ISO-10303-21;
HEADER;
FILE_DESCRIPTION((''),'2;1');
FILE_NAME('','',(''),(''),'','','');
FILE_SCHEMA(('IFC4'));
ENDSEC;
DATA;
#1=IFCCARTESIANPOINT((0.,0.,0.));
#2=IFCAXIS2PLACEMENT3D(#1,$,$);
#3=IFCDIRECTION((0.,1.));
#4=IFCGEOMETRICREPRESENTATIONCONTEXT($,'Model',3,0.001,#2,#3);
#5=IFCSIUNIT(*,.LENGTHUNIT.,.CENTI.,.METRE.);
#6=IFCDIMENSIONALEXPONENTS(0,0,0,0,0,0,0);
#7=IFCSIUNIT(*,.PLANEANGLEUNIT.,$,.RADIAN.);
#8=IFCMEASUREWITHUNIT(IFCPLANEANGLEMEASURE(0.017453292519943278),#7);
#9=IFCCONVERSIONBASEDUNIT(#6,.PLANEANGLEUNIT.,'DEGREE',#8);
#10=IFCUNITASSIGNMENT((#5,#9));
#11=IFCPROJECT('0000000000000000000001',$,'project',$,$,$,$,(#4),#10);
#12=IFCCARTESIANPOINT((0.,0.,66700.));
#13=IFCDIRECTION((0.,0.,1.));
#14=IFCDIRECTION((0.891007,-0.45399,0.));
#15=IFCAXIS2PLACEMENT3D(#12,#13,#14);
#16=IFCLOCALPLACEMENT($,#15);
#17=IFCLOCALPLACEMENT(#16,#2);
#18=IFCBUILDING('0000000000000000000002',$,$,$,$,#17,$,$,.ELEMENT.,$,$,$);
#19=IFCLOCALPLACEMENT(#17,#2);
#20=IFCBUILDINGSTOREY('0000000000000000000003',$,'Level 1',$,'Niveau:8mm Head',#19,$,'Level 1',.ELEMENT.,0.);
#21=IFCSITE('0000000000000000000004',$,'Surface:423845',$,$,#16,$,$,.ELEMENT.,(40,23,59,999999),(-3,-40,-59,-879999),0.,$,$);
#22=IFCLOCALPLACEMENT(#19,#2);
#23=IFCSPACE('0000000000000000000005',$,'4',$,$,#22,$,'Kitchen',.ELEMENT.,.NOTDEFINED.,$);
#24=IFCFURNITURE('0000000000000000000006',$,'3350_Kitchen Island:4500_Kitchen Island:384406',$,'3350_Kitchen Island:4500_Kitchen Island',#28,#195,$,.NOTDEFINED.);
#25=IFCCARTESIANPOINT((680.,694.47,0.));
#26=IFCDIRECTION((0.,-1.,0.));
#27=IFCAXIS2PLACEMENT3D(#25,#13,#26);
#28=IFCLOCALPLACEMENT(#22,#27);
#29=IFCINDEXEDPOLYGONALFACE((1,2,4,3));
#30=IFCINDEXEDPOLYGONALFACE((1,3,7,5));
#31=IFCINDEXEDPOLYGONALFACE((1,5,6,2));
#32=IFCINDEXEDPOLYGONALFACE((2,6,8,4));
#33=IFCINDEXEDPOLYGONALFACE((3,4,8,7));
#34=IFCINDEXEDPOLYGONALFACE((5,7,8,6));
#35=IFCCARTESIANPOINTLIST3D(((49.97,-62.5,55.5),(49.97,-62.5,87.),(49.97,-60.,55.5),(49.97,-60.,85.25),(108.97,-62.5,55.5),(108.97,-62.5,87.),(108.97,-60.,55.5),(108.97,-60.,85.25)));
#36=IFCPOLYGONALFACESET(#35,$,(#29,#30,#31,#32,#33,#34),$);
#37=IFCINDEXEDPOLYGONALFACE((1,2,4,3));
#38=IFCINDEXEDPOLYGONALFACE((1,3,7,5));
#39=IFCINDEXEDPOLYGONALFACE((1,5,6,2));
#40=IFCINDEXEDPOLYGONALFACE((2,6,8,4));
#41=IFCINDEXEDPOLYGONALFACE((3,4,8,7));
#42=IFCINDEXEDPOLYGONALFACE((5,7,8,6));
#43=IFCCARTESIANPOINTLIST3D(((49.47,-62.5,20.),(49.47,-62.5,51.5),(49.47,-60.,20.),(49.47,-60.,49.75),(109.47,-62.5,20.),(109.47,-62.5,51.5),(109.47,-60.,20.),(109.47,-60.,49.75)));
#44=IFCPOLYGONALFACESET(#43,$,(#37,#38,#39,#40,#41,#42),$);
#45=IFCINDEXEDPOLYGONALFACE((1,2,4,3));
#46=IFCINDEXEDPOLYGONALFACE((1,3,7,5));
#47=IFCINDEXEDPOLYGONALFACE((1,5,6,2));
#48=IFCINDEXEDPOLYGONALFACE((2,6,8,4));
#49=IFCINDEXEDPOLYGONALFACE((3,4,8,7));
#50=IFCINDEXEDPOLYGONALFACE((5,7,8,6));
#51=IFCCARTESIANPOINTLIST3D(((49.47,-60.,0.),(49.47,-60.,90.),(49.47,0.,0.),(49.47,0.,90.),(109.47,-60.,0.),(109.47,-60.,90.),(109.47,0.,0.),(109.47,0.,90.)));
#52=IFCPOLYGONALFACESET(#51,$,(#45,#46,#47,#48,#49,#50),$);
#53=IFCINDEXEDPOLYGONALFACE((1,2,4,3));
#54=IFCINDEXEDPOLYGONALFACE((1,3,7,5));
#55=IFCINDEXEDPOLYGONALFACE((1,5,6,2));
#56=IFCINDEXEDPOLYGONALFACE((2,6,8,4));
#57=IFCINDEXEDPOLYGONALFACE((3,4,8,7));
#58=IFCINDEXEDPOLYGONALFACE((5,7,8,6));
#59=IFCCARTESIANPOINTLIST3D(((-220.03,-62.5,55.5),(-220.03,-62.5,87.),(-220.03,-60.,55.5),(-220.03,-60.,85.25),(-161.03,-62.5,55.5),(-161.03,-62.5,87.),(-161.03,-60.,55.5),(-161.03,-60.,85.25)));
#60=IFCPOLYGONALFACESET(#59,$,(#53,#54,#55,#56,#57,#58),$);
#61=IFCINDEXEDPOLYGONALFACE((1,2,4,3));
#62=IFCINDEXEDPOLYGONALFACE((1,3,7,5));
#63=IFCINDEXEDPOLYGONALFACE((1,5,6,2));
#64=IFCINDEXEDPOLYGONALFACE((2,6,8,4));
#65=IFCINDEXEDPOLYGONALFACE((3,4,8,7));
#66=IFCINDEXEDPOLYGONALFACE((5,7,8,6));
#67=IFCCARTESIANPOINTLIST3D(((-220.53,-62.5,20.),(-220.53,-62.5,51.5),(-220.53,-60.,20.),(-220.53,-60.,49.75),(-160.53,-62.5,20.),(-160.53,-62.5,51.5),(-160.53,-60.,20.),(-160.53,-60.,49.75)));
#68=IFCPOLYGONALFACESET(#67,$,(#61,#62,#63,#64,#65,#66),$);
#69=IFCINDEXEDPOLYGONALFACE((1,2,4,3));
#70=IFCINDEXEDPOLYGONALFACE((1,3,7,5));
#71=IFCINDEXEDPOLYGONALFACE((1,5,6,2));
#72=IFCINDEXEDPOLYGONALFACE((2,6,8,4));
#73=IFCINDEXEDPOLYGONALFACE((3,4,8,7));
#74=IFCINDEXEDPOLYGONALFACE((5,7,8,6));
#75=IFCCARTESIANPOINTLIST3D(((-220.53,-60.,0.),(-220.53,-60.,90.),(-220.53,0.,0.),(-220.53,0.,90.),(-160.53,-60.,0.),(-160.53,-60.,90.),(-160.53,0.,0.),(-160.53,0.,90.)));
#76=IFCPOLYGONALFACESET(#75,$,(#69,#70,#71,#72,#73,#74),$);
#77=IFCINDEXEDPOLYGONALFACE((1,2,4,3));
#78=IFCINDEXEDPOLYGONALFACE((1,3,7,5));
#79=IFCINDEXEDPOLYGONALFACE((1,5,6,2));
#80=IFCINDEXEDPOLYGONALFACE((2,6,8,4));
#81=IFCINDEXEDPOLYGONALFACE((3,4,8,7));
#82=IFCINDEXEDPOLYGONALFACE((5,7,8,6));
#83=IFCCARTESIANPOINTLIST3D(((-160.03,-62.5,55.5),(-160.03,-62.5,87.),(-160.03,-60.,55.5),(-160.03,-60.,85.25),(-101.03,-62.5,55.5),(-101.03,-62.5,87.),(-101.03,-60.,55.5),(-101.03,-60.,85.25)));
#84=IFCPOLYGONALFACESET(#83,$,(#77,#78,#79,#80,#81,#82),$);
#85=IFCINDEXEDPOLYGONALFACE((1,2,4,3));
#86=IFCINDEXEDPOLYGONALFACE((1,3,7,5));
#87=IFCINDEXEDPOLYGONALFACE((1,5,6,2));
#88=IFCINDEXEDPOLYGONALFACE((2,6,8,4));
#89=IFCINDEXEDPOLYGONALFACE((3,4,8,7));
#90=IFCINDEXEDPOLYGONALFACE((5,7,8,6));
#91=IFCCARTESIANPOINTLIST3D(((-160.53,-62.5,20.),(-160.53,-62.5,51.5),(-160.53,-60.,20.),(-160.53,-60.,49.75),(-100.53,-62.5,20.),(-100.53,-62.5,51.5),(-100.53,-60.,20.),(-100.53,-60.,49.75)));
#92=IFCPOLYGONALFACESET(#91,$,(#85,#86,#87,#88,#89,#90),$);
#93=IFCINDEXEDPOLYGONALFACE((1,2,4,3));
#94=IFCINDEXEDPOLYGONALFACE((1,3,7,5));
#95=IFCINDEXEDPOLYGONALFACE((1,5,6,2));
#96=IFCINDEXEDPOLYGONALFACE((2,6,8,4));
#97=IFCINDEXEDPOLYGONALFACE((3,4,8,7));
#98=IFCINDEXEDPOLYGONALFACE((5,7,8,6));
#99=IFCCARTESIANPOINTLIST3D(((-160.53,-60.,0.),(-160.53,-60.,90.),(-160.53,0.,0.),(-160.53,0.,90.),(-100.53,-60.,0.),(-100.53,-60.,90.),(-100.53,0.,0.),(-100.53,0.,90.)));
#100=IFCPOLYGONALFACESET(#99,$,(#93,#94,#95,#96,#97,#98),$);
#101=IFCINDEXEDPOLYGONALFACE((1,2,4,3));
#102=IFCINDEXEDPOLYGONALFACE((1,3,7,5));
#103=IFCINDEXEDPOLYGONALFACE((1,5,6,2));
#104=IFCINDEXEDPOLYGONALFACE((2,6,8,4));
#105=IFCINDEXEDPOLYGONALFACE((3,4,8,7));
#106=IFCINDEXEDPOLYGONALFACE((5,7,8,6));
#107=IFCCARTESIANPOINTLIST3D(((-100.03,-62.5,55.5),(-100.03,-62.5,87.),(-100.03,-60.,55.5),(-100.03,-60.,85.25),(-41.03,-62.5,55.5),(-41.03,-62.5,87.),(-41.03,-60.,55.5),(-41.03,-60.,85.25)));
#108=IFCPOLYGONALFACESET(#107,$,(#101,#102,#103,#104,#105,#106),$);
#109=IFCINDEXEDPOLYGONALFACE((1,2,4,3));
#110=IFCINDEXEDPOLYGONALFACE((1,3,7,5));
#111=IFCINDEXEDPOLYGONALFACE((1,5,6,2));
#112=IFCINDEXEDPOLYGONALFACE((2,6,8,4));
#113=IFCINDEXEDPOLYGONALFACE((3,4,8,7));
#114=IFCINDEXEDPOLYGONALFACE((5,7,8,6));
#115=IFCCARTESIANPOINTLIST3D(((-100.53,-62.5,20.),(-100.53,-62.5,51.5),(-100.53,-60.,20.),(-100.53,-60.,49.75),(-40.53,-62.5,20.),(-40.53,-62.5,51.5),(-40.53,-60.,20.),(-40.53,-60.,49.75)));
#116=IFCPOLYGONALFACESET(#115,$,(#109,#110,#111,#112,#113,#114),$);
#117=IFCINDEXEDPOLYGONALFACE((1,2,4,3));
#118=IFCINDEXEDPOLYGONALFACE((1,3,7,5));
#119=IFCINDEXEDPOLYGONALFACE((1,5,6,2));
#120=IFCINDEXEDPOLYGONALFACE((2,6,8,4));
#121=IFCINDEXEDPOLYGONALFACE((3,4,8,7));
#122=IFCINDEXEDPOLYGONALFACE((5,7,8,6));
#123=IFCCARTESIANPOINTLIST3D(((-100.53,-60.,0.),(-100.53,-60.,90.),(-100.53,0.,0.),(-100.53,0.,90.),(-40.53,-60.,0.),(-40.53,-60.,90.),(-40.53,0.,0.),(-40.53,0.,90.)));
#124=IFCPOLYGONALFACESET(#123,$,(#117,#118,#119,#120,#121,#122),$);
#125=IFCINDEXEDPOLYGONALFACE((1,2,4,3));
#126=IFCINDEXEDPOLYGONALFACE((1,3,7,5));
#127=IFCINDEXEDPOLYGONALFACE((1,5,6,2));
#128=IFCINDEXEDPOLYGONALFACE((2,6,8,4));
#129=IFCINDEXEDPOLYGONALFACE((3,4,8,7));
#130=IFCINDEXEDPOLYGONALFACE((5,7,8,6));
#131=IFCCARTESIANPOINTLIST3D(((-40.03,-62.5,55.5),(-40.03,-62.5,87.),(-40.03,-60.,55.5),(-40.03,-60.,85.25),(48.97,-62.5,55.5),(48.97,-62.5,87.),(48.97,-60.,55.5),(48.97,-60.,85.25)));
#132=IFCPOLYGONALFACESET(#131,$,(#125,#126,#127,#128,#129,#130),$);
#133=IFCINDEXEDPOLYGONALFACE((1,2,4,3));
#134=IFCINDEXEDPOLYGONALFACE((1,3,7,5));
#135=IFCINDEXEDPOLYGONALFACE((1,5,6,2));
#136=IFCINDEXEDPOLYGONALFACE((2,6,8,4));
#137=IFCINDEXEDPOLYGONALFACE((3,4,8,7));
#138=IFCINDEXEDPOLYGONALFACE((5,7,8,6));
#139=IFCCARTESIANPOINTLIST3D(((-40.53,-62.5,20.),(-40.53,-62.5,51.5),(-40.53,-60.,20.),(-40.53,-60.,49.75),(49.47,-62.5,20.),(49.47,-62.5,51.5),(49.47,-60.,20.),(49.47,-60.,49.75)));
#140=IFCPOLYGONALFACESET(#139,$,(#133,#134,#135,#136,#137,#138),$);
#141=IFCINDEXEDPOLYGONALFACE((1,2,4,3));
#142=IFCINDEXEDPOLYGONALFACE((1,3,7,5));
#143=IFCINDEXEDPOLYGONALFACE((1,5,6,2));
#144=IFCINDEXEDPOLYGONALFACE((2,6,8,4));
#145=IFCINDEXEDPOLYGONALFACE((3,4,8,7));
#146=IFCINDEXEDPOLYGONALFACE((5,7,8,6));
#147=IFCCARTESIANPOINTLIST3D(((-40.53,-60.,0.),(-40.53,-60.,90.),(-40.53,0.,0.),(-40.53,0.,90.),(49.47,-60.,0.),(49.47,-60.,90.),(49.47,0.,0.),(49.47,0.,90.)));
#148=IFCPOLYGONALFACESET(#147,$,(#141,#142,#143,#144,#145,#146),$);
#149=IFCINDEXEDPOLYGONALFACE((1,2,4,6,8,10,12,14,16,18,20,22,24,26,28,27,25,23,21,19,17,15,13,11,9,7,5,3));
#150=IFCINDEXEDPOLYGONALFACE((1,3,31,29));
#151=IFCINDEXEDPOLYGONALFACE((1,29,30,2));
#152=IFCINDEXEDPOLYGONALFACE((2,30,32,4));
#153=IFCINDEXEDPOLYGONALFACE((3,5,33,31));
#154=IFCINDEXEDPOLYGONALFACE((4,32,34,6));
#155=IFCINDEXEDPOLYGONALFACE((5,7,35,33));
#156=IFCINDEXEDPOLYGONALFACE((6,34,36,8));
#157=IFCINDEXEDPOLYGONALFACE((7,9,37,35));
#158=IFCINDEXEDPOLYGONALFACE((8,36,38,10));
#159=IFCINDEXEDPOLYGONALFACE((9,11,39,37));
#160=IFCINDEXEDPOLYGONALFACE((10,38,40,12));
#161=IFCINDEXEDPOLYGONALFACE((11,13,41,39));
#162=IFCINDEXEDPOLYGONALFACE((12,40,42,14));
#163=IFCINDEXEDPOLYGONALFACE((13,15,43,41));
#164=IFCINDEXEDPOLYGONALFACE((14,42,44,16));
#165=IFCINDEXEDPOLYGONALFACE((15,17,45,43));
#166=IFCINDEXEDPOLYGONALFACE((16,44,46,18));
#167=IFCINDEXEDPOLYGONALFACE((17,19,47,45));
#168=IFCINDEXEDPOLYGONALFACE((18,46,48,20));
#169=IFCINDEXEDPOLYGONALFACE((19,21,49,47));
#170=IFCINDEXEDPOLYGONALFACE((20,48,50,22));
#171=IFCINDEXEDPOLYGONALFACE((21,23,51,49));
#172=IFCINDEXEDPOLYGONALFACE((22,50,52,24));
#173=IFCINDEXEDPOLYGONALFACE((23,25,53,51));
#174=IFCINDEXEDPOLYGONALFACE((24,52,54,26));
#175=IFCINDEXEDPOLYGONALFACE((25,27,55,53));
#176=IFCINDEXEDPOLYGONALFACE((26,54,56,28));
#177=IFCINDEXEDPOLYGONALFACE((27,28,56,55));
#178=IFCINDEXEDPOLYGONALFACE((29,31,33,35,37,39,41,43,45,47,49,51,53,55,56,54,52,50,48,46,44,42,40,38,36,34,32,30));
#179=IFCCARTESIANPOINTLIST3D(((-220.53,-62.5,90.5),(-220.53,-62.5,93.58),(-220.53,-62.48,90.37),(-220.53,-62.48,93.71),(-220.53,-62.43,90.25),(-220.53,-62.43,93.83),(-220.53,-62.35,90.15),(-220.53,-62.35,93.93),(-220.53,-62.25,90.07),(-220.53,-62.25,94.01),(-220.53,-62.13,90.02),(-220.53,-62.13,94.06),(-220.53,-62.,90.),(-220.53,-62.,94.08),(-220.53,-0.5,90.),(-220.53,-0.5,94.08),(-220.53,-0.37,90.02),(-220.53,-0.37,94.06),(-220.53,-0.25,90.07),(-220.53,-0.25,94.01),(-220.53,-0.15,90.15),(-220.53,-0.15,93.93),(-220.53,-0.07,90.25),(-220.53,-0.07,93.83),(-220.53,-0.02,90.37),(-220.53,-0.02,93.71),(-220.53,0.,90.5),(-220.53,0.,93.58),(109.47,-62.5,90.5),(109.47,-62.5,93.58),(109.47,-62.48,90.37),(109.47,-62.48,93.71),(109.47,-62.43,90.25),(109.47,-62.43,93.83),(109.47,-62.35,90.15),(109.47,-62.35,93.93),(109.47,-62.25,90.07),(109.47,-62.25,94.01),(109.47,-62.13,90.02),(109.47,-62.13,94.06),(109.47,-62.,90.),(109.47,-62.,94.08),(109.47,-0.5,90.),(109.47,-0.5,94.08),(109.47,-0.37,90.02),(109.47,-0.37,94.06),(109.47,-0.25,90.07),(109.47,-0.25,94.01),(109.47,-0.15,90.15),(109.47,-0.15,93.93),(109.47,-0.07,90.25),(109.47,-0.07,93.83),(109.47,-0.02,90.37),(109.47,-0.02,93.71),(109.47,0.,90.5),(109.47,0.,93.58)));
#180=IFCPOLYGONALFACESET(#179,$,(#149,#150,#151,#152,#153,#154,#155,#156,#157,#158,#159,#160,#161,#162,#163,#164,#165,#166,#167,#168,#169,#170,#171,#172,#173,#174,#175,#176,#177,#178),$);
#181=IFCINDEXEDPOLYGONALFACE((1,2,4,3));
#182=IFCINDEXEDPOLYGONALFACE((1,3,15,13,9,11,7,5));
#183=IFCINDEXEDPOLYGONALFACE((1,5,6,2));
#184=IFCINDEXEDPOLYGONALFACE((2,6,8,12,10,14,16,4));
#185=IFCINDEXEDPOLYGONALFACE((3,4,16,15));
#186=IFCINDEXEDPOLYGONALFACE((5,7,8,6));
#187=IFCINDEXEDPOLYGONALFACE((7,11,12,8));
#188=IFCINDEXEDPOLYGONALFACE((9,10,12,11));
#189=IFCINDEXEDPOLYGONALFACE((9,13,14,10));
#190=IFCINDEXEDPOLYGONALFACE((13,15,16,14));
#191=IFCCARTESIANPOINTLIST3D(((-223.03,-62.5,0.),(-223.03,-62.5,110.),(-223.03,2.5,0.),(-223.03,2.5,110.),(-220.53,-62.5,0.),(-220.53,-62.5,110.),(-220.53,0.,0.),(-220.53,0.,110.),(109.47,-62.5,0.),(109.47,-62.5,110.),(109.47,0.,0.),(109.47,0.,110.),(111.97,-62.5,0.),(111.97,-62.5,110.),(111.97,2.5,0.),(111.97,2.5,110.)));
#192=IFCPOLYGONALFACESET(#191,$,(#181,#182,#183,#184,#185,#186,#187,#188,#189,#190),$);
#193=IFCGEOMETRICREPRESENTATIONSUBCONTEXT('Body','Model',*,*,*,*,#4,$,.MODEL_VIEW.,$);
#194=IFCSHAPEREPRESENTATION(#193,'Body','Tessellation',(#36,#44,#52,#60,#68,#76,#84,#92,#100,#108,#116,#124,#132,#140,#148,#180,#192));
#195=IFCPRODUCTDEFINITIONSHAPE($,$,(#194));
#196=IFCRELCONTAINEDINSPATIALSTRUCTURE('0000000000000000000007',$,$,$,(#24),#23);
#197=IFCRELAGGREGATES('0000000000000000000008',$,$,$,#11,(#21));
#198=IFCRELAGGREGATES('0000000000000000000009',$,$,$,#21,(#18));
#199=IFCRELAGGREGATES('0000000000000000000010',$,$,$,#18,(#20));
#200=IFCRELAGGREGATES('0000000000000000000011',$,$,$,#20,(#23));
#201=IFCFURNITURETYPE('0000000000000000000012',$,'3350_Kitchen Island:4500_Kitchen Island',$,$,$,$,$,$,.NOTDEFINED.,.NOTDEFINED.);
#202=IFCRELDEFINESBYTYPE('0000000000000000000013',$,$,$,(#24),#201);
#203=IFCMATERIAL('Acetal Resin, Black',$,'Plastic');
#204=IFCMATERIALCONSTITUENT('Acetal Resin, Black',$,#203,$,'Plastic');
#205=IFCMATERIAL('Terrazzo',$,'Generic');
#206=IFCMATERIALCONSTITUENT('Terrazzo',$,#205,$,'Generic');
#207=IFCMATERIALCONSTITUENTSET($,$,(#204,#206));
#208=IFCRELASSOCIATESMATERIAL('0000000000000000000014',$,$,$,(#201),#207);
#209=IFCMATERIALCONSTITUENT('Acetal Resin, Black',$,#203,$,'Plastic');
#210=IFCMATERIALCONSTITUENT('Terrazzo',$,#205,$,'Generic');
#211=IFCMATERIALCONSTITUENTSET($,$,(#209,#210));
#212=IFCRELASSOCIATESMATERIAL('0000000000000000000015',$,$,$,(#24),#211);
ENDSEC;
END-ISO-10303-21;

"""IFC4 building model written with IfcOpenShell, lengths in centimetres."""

from ifc_helpers import new_model, entity, si_unit, converted_unit, direction, frame, frame_2d, origin, place, context, subcontext, project, spatial, polyline, circle_curve, parameter, trimmed, segment, composite_curve, rectangle, outline, extrude, source, transform, mapped, material, constituent, constituent_set, type_object, type_shapes, element, save


model = new_model("IFC4")

# Units and contexts
model_context = context("Model", 3, precision=0.001, world=origin(), true_north=direction((0.0, 1.0)))
body_context = subcontext(model_context, "Body", "Model", "MODEL_VIEW")
ifc_project = project(units=[si_unit("LENGTHUNIT", "METRE", prefix="CENTI"), converted_unit("PLANEANGLEUNIT", "DEGREE", entity("IfcPlaneAngleMeasure", 0.017453292519943278), si_unit("PLANEANGLEUNIT", "RADIAN"), dimensions=[0, 0, 0, 0, 0, 0, 0])], contexts=[model_context])

# Site, building, storey
site_placement = place(None, frame((0.0, 0.0, 66700.0), z_axis=(0.0, 0.0, 1.0), x_axis=(0.891007, -0.45399, 0.0)))
site = spatial("IfcSite", under=ifc_project, at=site_placement, Name="Surface:423845", CompositionType="ELEMENT", RefLatitude=(40, 23, 59, 999999), RefLongitude=(-3, -40, -59, -879999), RefElevation=0.0)
building_placement = place(site_placement, origin())
building = spatial("IfcBuilding", under=site, at=building_placement, CompositionType="ELEMENT")
storey_placement = place(building_placement, origin())
storey = spatial("IfcBuildingStorey", under=building, at=storey_placement, Name="Level 1", ObjectType="Niveau:8mm Head", LongName="Level 1", CompositionType="ELEMENT", Elevation=0.0)

# Shared definitions
space_placement = place(storey_placement, origin())
space = spatial("IfcSpace", under=storey, at=space_placement, Name="4", LongName="Kitchen", CompositionType="ELEMENT", PredefinedType="NOTDEFINED")

# Furniture
ifc_material_1 = material(Name="Acetal Resin, Black", Category="Plastic")
ifc_constituent_1 = constituent(ifc_material_1, Name="Acetal Resin, Black", Category="Plastic")
ifc_material_2 = material(Name="Terrazzo", Category="Generic")
ifc_constituent_2 = constituent(ifc_material_2, Name="Terrazzo", Category="Generic")
ifc_constituent_set_1 = constituent_set(constituents=[ifc_constituent_1, ifc_constituent_2])
ifc_constituent_3 = constituent(ifc_material_1, Name="Acetal Resin, Black", Category="Plastic")
ifc_constituent_4 = constituent(ifc_material_2, Name="Terrazzo", Category="Generic")
ifc_constituent_set_2 = constituent_set(constituents=[ifc_constituent_3, ifc_constituent_4])
furniture_type_1 = type_object("IfcFurnitureType", Name="3350_Kitchen Island:4500_Kitchen Island", AssemblyPlace="NOTDEFINED", PredefinedType="NOTDEFINED", material=ifc_constituent_set_2)
shared_shape_1 = source(origin(), body_context, "Body", "SweptSolid", [
    extrude(outline(polyline([(-1.25, -15.31), (1.25, -15.31), (1.25, 14.44), (-1.25, 16.19), (-1.25, -15.31)])), frame((49.97, -61.25, 70.81), z_axis=(1.0, 0.0, 0.0), x_axis=(0.0, 1.0, 0.0)), (0.0, 0.0, 1.0), 59.0),
    extrude(outline(polyline([(-1.25, -15.31), (1.25, -15.31), (1.25, 14.44), (-1.25, 16.19), (-1.25, -15.31)])), frame((49.47, -61.25, 35.31), z_axis=(1.0, 0.0, 0.0), x_axis=(0.0, 1.0, 0.0)), (0.0, 0.0, 1.0), 60.0),
    extrude(rectangle(XDim=60.0, YDim=60.0, at=frame_2d((0.0, 0.0), x_axis=(1.0, 0.0))), frame((79.47, -30.0, 0.0), z_axis=(0.0, 0.0, 1.0), x_axis=(-1.0, 0.0, 0.0)), (0.0, 0.0, 1.0), 90.0),
    extrude(outline(polyline([(-1.25, -15.31), (1.25, -15.31), (1.25, 14.44), (-1.25, 16.19), (-1.25, -15.31)])), frame((-220.03, -61.25, 70.81), z_axis=(1.0, 0.0, 0.0), x_axis=(0.0, 1.0, 0.0)), (0.0, 0.0, 1.0), 59.0),
    extrude(outline(polyline([(-1.25, -15.31), (1.25, -15.31), (1.25, 14.44), (-1.25, 16.19), (-1.25, -15.31)])), frame((-220.53, -61.25, 35.31), z_axis=(1.0, 0.0, 0.0), x_axis=(0.0, 1.0, 0.0)), (0.0, 0.0, 1.0), 60.0),
    extrude(rectangle(XDim=60.0, YDim=60.0, at=frame_2d((0.0, 0.0), x_axis=(1.0, 0.0))), frame((-190.53, -30.0, 0.0), z_axis=(0.0, 0.0, 1.0), x_axis=(-1.0, 0.0, 0.0)), (0.0, 0.0, 1.0), 90.0),
    extrude(outline(polyline([(-1.25, -15.31), (1.25, -15.31), (1.25, 14.44), (-1.25, 16.19), (-1.25, -15.31)])), frame((-160.03, -61.25, 70.81), z_axis=(1.0, 0.0, 0.0), x_axis=(0.0, 1.0, 0.0)), (0.0, 0.0, 1.0), 59.0),
    extrude(outline(polyline([(-1.25, -15.31), (1.25, -15.31), (1.25, 14.44), (-1.25, 16.19), (-1.25, -15.31)])), frame((-160.53, -61.25, 35.31), z_axis=(1.0, 0.0, 0.0), x_axis=(0.0, 1.0, 0.0)), (0.0, 0.0, 1.0), 60.0),
    extrude(rectangle(XDim=60.0, YDim=60.0, at=frame_2d((0.0, 0.0), x_axis=(1.0, 0.0))), frame((-130.53, -30.0, 0.0), z_axis=(0.0, 0.0, 1.0), x_axis=(-1.0, 0.0, 0.0)), (0.0, 0.0, 1.0), 90.0),
    extrude(outline(polyline([(-1.25, -15.31), (1.25, -15.31), (1.25, 14.44), (-1.25, 16.19), (-1.25, -15.31)])), frame((-100.03, -61.25, 70.81), z_axis=(1.0, 0.0, 0.0), x_axis=(0.0, 1.0, 0.0)), (0.0, 0.0, 1.0), 59.0),
    extrude(outline(polyline([(-1.25, -15.31), (1.25, -15.31), (1.25, 14.44), (-1.25, 16.19), (-1.25, -15.31)])), frame((-100.53, -61.25, 35.31), z_axis=(1.0, 0.0, 0.0), x_axis=(0.0, 1.0, 0.0)), (0.0, 0.0, 1.0), 60.0),
    extrude(rectangle(XDim=60.0, YDim=60.0, at=frame_2d((0.0, 0.0), x_axis=(1.0, 0.0))), frame((-70.53, -30.0, 0.0), z_axis=(0.0, 0.0, 1.0), x_axis=(-1.0, 0.0, 0.0)), (0.0, 0.0, 1.0), 90.0),
    extrude(outline(polyline([(-1.25, -15.31), (1.25, -15.31), (1.25, 14.44), (-1.25, 16.19), (-1.25, -15.31)])), frame((-40.03, -61.25, 70.81), z_axis=(1.0, 0.0, 0.0), x_axis=(0.0, 1.0, 0.0)), (0.0, 0.0, 1.0), 89.0),
    extrude(outline(polyline([(-1.25, -15.31), (1.25, -15.31), (1.25, 14.44), (-1.25, 16.19), (-1.25, -15.31)])), frame((-40.53, -61.25, 35.31), z_axis=(1.0, 0.0, 0.0), x_axis=(0.0, 1.0, 0.0)), (0.0, 0.0, 1.0), 90.0),
    extrude(rectangle(XDim=90.0, YDim=60.0, at=frame_2d((0.0, 0.0), x_axis=(1.0, 0.0))), frame((4.47, -30.0, 0.0), z_axis=(0.0, 0.0, 1.0), x_axis=(-1.0, 0.0, 0.0)), (0.0, 0.0, 1.0), 90.0),
    extrude(outline(composite_curve([segment(polyline([(-30.75, -2.04), (30.75, -2.04)]), True, "CONTINUOUS"), segment(trimmed(circle_curve(frame_2d((30.75, -1.54), x_axis=(1.0, 0.0)), 0.5), [parameter(270.0)], [parameter(0.0)], True, "PARAMETER"), True, "CONTINUOUS"), segment(polyline([(31.25, -1.54), (31.25, 1.54)]), True, "CONTINUOUS"), segment(trimmed(circle_curve(frame_2d((30.75, 1.54), x_axis=(1.0, 0.0)), 0.5), [parameter(0.0)], [parameter(90.0)], True, "PARAMETER"), True, "CONTINUOUS"), segment(polyline([(30.75, 2.04), (-30.75, 2.04)]), True, "CONTINUOUS"), segment(trimmed(circle_curve(frame_2d((-30.75, 1.54), x_axis=(1.0, 0.0)), 0.5), [parameter(90.0)], [parameter(180.0)], True, "PARAMETER"), True, "CONTINUOUS"), segment(polyline([(-31.25, 1.54), (-31.25, -1.54)]), True, "CONTINUOUS"), segment(trimmed(circle_curve(frame_2d((-30.75, -1.54), x_axis=(1.0, 0.0)), 0.5), [parameter(180.0)], [parameter(270.0)], True, "PARAMETER"), True, "CONTINUOUS")], self_intersect=False)), frame((-220.53, -31.25, 92.04), z_axis=(1.0, 0.0, 0.0), x_axis=(0.0, 1.0, 0.0)), (0.0, 0.0, 1.0), 330.0),
    extrude(outline(polyline([(-165.0, -30.63), (-165.0, 31.88), (-167.5, 31.88), (-167.5, -33.13), (167.5, -33.13), (167.5, 31.87), (165.0, 31.87), (165.0, -30.63), (-165.0, -30.63)])), frame((-55.53, -30.63, 0.0), z_axis=(0.0, 0.0, -1.0), x_axis=(1.0, 0.0, 0.0)), (0.0, 0.0, -1.0), 110.0),
])
type_shapes(furniture_type_1, [shared_shape_1])
furniture_1_placement = place(space_placement, frame((680.0, 694.47, 0.0), z_axis=(0.0, 0.0, 1.0), x_axis=(0.0, -1.0, 0.0)))
element("IfcFurniture", 1, at=furniture_1_placement, inside=space, type_object=furniture_type_1, material=ifc_constituent_set_1, Name="3350_Kitchen Island:4500_Kitchen Island:384406", ObjectType="3350_Kitchen Island:4500_Kitchen Island", PredefinedType="NOTDEFINED", context=body_context, shape_type="MappedRepresentation", body=[
    mapped(shared_shape_1, transform((0.0, 0.0, 0.0), scale=1.0)),
])

save(model, "model.ifc")
